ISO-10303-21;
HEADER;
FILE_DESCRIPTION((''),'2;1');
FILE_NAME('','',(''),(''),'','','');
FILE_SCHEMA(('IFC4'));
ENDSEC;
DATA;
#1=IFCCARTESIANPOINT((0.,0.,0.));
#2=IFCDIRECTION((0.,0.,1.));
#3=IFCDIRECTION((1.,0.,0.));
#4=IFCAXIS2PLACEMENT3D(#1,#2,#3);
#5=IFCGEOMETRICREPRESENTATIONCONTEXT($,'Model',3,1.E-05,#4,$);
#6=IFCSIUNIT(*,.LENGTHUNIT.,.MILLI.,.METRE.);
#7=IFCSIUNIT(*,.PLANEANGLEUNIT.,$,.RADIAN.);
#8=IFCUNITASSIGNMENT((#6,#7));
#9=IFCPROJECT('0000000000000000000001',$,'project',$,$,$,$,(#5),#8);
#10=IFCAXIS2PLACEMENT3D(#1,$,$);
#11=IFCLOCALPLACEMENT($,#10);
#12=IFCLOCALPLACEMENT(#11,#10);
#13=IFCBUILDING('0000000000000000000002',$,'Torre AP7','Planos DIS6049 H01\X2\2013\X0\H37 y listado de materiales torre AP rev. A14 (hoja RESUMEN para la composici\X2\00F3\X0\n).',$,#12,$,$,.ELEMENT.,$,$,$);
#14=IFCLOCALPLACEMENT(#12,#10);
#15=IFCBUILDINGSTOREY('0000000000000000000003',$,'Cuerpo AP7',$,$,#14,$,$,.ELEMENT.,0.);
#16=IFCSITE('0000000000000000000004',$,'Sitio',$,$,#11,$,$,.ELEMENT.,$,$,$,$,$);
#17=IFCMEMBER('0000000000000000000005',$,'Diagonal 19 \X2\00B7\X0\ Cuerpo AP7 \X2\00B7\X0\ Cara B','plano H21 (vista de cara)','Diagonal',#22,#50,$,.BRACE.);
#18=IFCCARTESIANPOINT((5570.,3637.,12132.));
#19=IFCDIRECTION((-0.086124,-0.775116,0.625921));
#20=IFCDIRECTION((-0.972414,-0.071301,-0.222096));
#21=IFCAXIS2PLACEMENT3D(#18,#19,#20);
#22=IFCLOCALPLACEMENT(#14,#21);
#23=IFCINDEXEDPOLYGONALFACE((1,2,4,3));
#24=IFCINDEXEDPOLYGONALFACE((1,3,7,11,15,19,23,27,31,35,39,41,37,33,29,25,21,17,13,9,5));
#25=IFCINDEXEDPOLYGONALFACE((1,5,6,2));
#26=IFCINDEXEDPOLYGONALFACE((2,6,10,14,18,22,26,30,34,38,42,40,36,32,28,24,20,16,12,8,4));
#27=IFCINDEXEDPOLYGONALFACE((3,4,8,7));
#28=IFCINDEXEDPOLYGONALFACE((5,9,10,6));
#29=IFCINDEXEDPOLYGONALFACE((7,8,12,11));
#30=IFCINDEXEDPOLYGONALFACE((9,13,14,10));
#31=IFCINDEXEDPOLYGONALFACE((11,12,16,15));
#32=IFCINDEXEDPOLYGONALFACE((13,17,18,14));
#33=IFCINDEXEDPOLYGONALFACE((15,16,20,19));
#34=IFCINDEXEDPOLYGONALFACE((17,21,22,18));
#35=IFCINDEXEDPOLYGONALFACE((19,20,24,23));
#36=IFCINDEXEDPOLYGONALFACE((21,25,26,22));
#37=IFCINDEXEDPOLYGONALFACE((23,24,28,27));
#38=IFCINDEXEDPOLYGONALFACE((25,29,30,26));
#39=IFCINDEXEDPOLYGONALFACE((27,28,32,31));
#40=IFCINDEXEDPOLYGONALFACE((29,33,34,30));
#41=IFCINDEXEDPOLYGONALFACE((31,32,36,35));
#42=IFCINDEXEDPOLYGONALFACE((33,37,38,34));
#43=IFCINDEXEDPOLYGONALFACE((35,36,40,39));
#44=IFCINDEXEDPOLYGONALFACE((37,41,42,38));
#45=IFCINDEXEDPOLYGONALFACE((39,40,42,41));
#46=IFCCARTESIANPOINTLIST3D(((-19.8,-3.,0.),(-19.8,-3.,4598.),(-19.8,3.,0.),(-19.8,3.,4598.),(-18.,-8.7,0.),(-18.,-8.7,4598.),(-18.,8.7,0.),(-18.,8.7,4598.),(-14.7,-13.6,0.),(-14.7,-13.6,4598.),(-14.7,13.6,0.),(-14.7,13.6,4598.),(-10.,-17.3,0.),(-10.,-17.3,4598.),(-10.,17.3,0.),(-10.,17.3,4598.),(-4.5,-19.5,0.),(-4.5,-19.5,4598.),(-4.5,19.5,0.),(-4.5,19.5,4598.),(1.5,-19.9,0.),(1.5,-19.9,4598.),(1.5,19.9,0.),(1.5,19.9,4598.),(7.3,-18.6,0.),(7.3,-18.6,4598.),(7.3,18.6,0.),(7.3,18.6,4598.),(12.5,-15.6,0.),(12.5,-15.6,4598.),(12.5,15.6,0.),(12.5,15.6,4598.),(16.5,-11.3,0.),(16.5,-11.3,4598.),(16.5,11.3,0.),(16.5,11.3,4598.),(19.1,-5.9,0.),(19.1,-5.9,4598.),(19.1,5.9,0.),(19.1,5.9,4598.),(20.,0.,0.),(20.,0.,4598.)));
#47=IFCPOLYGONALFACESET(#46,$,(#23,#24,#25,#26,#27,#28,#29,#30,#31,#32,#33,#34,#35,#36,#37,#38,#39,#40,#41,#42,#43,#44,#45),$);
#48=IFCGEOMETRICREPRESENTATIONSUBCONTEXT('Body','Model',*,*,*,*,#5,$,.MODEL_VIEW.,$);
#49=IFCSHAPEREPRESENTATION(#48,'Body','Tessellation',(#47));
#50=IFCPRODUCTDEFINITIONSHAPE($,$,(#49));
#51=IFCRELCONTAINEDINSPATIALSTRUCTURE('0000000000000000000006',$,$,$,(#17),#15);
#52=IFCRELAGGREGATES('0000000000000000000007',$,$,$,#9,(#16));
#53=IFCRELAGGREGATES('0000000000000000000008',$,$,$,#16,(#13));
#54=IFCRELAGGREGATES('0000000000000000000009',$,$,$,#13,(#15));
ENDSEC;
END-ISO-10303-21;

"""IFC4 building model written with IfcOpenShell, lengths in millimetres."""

from ifc_helpers import new_model, si_unit, frame, origin, origin_with_axes, place, context, subcontext, project, spatial, circle, extrude, element, save


model = new_model("IFC4")

# Units and contexts
model_context = context("Model", 3, precision=1e-05, world=origin_with_axes())
body_context = subcontext(model_context, "Body", "Model", "MODEL_VIEW")
ifc_project = project(units=[si_unit("LENGTHUNIT", "METRE", prefix="MILLI"), si_unit("PLANEANGLEUNIT", "RADIAN")], contexts=[model_context])

# Site, building, storey
site_placement = place(None, origin())
site = spatial("IfcSite", under=ifc_project, at=site_placement, Name="Sitio", CompositionType="ELEMENT")
building_placement = place(site_placement, origin())
building = spatial("IfcBuilding", under=site, at=building_placement, Name="Torre AP7", Description="Planos DIS6049 H01–H37 y listado de materiales torre AP rev. A14 (hoja RESUMEN para la composición).", CompositionType="ELEMENT")
storey_placement = place(building_placement, origin())
storey = spatial("IfcBuildingStorey", under=building, at=storey_placement, Name="Cuerpo AP7", CompositionType="ELEMENT", Elevation=0.0)

# Member
member_1_placement = place(storey_placement, frame((5570.0, 3637.0, 12132.0), z_axis=(-0.086124, -0.775116, 0.625921), x_axis=(-0.972414, -0.071301, -0.222096)))
element("IfcMember", 1, at=member_1_placement, inside=storey, Name="Diagonal 19 · Cuerpo AP7 · Cara B", Description="plano H21 (vista de cara)", ObjectType="Diagonal", PredefinedType="BRACE", context=body_context, shape_type="SweptSolid", body=[
    extrude(circle(Radius=20.0), None, (0.0, 0.0, 1.0), 4598.0),
])

save(model, "model.ifc")
